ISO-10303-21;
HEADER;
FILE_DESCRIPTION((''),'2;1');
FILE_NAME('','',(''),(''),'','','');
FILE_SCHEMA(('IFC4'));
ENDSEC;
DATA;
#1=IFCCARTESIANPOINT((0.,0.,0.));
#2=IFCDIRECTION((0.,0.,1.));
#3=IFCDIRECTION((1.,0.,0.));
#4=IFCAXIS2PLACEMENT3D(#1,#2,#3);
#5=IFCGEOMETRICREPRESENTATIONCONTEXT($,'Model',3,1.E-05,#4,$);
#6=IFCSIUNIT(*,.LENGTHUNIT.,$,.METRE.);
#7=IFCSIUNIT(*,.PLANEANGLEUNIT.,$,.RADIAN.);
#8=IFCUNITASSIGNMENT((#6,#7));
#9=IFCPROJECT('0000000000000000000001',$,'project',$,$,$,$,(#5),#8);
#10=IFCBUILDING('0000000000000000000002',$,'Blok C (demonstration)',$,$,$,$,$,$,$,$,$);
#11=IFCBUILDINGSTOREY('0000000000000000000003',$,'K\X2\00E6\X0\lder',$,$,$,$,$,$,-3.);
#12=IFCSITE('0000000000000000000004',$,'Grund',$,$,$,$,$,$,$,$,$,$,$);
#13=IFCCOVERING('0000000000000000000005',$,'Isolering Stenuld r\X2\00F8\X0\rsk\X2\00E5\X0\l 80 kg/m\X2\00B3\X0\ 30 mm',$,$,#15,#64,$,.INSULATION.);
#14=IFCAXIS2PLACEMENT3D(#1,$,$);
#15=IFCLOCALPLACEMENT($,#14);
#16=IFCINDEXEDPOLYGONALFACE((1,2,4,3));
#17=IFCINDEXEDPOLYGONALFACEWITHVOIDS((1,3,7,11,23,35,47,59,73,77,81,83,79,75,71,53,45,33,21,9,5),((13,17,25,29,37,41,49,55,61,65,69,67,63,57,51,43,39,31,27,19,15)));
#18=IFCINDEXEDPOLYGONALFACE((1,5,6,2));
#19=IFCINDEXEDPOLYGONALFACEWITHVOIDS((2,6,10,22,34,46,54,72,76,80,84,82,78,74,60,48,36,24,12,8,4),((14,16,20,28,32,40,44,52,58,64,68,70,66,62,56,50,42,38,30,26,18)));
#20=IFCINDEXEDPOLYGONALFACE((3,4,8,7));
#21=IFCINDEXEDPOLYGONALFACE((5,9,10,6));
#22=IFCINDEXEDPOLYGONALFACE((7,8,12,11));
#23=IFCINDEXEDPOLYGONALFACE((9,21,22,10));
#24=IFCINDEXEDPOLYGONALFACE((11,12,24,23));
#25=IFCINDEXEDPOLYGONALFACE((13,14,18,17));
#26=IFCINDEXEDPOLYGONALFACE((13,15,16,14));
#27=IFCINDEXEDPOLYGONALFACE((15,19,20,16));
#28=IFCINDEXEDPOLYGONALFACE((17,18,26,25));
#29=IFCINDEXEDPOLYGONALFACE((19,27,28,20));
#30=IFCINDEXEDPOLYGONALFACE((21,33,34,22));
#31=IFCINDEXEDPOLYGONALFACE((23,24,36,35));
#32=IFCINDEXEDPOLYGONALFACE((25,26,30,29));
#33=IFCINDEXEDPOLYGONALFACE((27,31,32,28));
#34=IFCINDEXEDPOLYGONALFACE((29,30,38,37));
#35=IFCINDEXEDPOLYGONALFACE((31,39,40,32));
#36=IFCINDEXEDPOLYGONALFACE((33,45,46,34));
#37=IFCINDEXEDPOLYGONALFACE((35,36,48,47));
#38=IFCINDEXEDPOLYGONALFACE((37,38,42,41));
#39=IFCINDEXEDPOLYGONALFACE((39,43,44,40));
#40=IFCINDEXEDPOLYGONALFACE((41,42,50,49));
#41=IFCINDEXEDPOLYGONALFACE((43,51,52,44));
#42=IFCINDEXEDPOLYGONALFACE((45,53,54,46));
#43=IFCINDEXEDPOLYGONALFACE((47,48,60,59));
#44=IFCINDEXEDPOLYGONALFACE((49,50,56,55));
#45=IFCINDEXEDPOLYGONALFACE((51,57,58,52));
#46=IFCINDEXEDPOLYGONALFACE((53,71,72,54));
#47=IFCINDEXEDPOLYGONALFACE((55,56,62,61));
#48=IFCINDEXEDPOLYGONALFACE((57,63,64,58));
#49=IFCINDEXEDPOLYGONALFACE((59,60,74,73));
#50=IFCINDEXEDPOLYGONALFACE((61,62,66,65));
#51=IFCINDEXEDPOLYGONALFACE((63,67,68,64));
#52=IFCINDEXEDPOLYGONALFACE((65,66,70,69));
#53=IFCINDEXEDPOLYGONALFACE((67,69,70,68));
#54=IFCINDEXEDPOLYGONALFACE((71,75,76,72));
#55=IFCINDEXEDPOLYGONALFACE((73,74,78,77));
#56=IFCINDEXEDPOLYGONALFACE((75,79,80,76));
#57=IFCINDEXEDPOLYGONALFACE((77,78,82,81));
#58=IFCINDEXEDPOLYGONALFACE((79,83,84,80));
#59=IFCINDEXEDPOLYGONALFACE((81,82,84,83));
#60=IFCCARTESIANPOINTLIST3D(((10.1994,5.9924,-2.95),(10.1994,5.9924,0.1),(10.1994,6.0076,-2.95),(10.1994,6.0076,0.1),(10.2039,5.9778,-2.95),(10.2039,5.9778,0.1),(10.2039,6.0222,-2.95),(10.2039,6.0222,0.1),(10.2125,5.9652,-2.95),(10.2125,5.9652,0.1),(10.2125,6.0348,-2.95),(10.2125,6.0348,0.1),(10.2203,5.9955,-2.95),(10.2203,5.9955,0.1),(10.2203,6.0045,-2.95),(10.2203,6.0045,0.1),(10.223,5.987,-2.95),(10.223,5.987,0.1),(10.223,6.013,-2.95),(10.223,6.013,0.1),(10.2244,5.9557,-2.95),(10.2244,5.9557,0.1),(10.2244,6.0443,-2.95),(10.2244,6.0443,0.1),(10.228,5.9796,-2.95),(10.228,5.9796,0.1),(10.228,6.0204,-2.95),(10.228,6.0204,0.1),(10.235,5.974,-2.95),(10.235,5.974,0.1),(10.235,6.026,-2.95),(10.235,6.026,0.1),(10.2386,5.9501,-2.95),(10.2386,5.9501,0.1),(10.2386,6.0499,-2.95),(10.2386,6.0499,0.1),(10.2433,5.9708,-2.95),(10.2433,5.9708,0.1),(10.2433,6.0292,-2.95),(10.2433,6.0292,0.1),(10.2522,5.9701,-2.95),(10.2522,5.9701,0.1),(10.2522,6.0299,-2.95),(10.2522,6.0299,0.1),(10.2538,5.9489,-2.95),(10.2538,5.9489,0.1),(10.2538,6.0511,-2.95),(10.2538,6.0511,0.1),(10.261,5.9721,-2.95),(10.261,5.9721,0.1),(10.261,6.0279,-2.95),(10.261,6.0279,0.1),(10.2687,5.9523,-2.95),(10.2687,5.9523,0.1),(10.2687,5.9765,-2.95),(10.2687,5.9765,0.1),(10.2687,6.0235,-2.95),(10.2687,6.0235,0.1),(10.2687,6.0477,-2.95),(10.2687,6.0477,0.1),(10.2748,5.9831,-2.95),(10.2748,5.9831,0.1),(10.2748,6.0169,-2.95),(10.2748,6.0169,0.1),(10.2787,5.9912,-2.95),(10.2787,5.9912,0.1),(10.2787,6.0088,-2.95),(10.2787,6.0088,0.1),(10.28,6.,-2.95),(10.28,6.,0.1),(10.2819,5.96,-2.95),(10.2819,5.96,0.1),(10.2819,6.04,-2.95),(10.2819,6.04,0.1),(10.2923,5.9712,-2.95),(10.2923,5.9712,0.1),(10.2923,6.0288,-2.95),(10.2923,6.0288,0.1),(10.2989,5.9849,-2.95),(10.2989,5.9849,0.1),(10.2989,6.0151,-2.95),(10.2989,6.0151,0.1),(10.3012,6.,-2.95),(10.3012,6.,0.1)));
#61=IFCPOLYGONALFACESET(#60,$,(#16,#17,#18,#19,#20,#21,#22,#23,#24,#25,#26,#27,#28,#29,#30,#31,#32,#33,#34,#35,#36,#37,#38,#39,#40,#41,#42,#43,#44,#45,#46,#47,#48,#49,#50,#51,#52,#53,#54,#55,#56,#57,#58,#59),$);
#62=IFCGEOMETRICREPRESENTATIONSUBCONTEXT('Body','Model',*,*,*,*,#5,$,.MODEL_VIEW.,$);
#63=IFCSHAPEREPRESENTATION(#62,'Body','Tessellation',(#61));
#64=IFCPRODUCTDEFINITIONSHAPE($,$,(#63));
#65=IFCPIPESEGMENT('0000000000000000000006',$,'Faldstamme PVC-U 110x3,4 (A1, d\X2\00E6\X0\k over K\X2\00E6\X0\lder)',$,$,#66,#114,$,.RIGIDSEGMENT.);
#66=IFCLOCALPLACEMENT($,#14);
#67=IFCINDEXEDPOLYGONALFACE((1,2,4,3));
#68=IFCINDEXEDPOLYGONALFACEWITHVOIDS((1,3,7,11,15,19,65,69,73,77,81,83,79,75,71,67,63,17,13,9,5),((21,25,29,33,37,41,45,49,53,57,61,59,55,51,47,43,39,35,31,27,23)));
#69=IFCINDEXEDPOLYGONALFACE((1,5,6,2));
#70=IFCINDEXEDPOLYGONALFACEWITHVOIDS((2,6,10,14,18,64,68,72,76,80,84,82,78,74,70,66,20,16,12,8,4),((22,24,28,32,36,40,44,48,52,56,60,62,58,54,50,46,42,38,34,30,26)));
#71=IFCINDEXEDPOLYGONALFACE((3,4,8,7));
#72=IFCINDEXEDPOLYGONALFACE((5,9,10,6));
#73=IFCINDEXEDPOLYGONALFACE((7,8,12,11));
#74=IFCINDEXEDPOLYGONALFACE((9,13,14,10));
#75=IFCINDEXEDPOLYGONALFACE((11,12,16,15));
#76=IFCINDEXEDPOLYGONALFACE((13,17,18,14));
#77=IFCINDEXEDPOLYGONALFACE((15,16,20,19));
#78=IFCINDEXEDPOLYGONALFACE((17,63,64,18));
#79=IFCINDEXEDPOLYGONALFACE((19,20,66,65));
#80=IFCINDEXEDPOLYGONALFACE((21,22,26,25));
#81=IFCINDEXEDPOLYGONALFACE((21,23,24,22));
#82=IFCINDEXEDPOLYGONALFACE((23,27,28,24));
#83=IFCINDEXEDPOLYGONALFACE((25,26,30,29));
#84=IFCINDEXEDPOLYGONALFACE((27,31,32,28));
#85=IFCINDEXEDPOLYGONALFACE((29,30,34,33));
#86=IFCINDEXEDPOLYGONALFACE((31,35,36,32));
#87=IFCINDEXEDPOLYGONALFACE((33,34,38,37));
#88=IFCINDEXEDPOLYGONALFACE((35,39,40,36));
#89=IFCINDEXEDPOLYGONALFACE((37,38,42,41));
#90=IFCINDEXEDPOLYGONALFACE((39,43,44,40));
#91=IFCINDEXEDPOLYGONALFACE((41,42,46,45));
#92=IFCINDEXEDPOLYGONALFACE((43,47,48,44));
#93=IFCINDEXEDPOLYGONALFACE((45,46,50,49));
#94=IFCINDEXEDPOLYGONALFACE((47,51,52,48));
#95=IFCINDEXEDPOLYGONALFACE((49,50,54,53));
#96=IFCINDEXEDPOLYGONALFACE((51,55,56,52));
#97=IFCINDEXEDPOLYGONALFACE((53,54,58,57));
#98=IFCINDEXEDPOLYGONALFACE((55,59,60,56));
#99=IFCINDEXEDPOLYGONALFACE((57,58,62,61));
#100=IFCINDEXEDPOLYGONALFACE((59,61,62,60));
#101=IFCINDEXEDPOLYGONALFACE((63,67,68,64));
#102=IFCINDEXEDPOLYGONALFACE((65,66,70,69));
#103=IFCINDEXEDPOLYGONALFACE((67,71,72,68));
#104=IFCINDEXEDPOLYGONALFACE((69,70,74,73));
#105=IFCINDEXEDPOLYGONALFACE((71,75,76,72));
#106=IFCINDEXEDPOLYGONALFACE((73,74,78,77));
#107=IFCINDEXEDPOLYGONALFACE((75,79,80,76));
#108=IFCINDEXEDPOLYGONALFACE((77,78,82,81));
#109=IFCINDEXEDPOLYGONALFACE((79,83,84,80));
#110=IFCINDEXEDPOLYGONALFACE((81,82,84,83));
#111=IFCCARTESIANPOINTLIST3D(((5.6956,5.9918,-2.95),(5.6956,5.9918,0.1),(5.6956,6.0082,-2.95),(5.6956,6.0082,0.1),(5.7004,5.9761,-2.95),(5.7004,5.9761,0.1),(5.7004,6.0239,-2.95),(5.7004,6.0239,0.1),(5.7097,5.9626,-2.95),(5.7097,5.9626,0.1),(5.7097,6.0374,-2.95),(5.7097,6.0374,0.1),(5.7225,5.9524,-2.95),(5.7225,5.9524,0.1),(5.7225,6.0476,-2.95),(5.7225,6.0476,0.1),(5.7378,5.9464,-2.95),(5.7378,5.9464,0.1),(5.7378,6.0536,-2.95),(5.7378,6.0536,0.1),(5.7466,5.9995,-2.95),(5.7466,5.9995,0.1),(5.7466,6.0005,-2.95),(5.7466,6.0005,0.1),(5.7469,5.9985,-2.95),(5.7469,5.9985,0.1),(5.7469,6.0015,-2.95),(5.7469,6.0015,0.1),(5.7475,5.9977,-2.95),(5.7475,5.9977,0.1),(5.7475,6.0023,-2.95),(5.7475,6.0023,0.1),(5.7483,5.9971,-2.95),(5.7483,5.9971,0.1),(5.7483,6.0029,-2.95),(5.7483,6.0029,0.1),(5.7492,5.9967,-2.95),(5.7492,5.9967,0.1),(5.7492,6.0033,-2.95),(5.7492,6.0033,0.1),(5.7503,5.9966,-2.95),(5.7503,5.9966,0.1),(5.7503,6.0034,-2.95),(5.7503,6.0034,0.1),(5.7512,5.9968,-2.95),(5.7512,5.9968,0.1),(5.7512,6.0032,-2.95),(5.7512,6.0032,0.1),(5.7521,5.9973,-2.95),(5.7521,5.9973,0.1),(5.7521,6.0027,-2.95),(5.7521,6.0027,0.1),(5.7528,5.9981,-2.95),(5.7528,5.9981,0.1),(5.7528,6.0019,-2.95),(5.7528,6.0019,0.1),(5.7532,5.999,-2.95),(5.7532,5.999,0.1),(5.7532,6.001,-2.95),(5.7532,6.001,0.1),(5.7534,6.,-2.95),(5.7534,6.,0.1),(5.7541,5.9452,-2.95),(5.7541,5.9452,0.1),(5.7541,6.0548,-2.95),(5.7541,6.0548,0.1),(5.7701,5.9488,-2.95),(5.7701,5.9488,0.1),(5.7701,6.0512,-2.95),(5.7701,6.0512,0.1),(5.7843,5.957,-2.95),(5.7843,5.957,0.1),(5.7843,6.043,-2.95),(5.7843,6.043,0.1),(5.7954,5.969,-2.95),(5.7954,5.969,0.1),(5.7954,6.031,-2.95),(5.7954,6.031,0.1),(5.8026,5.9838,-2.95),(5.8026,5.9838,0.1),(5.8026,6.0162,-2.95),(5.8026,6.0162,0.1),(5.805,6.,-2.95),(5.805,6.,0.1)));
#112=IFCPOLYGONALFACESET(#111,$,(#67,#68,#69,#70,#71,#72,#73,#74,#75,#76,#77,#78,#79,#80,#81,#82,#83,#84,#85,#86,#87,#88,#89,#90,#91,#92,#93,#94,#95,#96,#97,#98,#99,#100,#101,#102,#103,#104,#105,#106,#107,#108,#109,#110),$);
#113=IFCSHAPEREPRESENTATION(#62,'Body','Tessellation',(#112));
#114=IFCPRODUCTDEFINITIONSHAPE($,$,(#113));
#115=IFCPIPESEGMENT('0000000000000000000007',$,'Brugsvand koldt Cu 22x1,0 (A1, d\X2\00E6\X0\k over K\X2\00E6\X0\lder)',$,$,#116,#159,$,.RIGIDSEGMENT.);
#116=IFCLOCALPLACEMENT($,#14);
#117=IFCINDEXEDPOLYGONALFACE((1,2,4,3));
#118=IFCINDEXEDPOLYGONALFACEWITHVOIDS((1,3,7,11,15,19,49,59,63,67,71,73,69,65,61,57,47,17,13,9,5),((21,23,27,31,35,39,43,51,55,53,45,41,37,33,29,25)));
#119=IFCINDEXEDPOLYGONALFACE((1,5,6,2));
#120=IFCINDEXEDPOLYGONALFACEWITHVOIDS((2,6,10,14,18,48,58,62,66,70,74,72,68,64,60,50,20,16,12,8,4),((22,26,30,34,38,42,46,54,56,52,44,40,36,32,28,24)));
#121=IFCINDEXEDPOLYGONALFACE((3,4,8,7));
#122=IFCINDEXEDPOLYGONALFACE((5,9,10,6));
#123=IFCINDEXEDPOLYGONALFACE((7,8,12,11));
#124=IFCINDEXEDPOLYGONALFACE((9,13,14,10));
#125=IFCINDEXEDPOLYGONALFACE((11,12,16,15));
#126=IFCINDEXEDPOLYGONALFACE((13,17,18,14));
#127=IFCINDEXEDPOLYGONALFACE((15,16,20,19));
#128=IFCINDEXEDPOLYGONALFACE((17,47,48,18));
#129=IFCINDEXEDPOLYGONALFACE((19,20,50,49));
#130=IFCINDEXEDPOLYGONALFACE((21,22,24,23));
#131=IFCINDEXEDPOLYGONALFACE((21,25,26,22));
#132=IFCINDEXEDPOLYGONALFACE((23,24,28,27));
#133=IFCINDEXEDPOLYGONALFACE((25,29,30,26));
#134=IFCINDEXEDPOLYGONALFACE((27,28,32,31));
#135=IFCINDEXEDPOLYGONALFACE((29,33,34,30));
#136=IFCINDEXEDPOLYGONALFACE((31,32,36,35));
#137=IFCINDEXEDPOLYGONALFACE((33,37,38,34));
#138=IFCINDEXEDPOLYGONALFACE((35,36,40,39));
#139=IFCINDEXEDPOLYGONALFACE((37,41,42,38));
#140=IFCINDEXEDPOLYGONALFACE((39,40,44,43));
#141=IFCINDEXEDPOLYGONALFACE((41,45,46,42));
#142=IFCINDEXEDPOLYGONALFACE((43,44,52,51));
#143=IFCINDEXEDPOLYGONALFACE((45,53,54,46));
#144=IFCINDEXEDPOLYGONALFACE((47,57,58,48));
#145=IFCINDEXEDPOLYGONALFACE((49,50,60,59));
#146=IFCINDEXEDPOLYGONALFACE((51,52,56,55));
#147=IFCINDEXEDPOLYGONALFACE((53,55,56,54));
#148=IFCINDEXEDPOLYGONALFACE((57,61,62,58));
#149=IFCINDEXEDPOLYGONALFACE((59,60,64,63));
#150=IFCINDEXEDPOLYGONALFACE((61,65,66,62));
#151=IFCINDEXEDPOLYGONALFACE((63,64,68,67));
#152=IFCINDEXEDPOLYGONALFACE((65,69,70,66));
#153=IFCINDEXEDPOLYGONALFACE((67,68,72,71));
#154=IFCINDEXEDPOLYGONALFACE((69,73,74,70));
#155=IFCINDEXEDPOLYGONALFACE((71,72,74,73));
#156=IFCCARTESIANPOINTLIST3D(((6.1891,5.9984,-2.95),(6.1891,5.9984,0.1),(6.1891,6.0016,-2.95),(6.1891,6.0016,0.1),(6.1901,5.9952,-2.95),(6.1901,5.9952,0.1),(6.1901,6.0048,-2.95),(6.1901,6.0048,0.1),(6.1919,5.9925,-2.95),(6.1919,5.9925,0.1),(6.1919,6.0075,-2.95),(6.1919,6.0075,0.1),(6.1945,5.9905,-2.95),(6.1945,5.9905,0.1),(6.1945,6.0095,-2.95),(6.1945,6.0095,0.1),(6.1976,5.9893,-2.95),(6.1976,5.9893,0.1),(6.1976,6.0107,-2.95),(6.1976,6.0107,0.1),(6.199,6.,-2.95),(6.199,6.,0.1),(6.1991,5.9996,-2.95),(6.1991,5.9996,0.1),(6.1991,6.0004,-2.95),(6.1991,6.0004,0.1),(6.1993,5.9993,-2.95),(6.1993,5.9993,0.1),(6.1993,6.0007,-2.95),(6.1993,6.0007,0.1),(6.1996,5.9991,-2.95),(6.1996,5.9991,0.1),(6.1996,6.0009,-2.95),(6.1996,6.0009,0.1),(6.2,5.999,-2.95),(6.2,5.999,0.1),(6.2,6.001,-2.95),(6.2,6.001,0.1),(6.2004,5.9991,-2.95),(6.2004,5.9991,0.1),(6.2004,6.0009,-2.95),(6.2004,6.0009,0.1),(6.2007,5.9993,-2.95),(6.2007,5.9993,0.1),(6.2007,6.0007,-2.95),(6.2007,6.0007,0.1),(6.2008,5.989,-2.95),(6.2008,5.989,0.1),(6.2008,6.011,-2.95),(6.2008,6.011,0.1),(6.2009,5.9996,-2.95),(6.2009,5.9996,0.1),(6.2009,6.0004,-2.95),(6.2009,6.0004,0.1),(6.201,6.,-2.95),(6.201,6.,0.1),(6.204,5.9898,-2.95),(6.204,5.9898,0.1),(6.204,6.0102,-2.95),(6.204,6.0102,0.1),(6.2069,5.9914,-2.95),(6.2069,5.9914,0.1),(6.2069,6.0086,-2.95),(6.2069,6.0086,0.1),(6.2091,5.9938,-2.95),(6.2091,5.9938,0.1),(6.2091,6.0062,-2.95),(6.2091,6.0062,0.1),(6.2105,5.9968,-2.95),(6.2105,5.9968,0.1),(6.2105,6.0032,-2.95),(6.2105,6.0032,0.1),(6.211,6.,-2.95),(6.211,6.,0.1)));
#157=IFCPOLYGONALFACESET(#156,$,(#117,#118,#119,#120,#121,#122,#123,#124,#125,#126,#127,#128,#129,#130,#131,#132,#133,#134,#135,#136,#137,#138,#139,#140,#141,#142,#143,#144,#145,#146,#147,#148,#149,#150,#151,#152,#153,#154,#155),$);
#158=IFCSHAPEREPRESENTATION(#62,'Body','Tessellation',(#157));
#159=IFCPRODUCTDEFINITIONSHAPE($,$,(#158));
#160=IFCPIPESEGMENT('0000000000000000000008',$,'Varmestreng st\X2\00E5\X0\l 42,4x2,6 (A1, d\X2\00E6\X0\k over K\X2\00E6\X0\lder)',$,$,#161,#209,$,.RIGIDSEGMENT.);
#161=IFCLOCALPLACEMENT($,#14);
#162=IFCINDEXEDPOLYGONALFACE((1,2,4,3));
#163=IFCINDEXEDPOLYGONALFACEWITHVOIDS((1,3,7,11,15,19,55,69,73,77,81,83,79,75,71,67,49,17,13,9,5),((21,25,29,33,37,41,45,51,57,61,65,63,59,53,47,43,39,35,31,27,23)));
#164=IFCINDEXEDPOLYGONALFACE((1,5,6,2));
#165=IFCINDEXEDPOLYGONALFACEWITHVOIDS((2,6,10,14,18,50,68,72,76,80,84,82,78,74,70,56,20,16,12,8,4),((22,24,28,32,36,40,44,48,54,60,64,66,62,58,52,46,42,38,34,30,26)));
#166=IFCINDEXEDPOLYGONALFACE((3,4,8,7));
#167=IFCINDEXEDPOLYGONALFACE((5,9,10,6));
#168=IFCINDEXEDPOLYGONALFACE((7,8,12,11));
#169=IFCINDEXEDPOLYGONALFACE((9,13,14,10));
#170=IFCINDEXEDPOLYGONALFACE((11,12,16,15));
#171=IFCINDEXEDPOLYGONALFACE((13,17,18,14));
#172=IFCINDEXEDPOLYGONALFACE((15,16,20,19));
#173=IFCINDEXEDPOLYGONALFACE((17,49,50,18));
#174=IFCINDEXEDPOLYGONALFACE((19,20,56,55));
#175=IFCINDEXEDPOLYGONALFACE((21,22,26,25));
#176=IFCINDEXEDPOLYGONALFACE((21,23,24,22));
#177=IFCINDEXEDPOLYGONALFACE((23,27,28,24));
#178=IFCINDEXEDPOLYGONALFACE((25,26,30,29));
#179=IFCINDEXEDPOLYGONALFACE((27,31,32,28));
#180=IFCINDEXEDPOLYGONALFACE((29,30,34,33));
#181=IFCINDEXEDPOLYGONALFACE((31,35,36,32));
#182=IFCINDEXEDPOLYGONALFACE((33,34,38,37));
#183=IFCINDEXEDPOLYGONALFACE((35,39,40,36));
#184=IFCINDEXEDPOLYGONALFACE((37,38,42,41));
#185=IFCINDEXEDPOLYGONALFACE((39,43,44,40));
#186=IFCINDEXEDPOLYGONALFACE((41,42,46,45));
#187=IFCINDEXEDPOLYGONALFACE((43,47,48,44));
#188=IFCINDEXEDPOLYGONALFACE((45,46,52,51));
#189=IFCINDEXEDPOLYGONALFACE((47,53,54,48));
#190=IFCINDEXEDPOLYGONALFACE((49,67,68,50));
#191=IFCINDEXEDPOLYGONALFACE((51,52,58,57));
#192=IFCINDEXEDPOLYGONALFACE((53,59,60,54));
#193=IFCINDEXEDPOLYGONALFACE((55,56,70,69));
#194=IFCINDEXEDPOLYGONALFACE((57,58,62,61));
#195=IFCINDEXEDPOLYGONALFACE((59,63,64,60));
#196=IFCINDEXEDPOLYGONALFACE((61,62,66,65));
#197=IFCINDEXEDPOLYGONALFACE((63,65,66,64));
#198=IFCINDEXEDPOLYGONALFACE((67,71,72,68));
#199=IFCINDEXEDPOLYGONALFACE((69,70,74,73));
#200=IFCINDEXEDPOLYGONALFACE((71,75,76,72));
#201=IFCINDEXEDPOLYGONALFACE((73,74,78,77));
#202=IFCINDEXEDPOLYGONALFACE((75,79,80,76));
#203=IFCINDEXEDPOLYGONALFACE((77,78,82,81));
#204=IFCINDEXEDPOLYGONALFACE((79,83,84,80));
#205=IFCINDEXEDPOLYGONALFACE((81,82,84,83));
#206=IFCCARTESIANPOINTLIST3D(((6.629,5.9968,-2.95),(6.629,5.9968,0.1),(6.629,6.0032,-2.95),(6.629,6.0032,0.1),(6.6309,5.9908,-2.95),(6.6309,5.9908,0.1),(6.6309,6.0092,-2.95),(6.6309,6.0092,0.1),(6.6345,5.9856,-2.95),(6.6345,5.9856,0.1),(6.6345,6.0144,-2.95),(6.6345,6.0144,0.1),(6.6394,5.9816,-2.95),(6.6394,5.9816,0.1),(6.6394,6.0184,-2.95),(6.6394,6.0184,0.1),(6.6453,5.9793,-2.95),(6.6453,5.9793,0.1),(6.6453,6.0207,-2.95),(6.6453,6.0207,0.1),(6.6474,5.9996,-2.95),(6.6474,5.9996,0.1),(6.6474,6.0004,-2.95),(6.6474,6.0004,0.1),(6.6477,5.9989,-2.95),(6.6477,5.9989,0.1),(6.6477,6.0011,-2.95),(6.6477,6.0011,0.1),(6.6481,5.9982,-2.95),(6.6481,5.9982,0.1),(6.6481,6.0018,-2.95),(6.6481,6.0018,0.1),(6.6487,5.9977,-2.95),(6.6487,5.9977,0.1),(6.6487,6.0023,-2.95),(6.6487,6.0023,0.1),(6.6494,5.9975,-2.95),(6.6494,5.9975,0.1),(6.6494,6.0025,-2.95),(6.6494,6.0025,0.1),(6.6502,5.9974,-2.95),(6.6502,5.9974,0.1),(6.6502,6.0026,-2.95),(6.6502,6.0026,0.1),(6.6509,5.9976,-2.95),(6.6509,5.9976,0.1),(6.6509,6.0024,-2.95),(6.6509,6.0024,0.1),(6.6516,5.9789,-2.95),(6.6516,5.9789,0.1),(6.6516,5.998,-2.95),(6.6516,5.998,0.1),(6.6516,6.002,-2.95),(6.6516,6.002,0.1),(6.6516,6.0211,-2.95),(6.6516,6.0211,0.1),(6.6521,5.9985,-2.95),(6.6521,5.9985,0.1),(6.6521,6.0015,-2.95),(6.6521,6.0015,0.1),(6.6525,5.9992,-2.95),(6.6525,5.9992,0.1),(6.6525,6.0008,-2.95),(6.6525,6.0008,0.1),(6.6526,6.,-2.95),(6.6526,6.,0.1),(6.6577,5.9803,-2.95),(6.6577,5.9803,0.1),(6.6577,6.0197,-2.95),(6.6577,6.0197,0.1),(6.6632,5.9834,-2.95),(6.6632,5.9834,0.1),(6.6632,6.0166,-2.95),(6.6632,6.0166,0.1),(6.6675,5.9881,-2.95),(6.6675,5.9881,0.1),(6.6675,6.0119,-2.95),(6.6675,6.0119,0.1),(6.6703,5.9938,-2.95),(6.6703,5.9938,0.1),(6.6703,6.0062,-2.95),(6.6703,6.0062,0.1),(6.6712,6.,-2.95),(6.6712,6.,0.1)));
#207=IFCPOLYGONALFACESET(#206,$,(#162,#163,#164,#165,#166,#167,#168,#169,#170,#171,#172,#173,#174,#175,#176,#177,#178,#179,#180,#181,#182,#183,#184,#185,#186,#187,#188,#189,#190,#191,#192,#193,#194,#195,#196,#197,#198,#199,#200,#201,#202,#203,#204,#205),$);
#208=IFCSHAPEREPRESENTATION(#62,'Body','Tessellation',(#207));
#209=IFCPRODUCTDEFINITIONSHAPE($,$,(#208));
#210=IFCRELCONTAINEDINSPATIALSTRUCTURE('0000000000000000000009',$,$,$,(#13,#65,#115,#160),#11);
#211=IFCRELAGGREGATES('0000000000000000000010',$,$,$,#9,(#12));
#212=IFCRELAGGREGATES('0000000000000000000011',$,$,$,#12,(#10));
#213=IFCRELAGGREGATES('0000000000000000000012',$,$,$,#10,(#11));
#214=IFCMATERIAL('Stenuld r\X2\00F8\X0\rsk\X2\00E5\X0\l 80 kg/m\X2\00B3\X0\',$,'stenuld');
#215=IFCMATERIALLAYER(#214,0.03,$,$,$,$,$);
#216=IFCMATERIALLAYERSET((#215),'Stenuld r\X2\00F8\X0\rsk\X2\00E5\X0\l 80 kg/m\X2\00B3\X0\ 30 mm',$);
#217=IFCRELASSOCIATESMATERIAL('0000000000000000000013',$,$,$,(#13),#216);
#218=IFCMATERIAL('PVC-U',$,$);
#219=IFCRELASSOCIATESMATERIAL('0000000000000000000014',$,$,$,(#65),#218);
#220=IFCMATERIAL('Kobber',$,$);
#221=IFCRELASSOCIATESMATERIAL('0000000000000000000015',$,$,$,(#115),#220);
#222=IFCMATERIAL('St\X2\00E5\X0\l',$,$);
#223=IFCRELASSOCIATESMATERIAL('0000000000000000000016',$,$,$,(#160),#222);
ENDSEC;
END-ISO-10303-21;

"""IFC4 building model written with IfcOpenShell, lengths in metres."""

from ifc_helpers import new_model, si_unit, frame, origin_with_axes, place, context, subcontext, project, spatial, hollow_circle, extrude, material, layer, layer_set, element, save


model = new_model("IFC4")

# Units and contexts
model_context = context("Model", 3, precision=1e-05, world=origin_with_axes())
body_context = subcontext(model_context, "Body", "Model", "MODEL_VIEW")
ifc_project = project(units=[si_unit("LENGTHUNIT", "METRE"), si_unit("PLANEANGLEUNIT", "RADIAN")], contexts=[model_context])

# Site, building, storey
site = spatial("IfcSite", under=ifc_project, Name="Grund")
building = spatial("IfcBuilding", under=site, Name="Blok C (demonstration)")
storey = spatial("IfcBuildingStorey", under=building, Name="Kælder", Elevation=-3.0)

# Covering
ifc_material_1 = material(Name="Stenuld rørskål 80 kg/m³", Category="stenuld")
ifc_layer_1 = layer(ifc_material_1, 0.03)
ifc_layer_set_1 = layer_set([ifc_layer_1], Name="Stenuld rørskål 80 kg/m³ 30 mm")
covering_1_placement = place(None, origin_with_axes())
element("IfcCovering", 1, at=covering_1_placement, inside=storey, material=ifc_layer_set_1, Name="Isolering Stenuld rørskål 80 kg/m³ 30 mm", PredefinedType="INSULATION", context=body_context, shape_type="SweptSolid", body=[
    extrude(hollow_circle(Radius=0.0512, WallThickness=0.0212), frame((10.25, 6.0, -2.95), z_axis=(0.0, 0.0, 1.0), x_axis=(1.0, 0.0, 0.0)), (0.0, 0.0, 1.0), 3.05),
])

# Pipe segments
ifc_material_2 = material(Name="PVC-U")
pipe_segment_1_placement = place(None, origin_with_axes())
element("IfcPipeSegment", 2, at=pipe_segment_1_placement, inside=storey, material=ifc_material_2, Name="Faldstamme PVC-U 110x3,4 (A1, dæk over Kælder)", PredefinedType="RIGIDSEGMENT", context=body_context, shape_type="SweptSolid", body=[
    extrude(hollow_circle(Radius=0.055, WallThickness=0.0516), frame((5.75, 6.0, -2.95), z_axis=(0.0, 0.0, 1.0), x_axis=(1.0, 0.0, 0.0)), (0.0, 0.0, 1.0), 3.05),
])
ifc_material_3 = material(Name="Kobber")
pipe_segment_2_placement = place(None, origin_with_axes())
element("IfcPipeSegment", 3, at=pipe_segment_2_placement, inside=storey, material=ifc_material_3, Name="Brugsvand koldt Cu 22x1,0 (A1, dæk over Kælder)", PredefinedType="RIGIDSEGMENT", context=body_context, shape_type="SweptSolid", body=[
    extrude(hollow_circle(Radius=0.011, WallThickness=0.01), frame((6.2, 6.0, -2.95), z_axis=(0.0, 0.0, 1.0), x_axis=(1.0, 0.0, 0.0)), (0.0, 0.0, 1.0), 3.05),
])
ifc_material_4 = material(Name="Stål")
pipe_segment_3_placement = place(None, origin_with_axes())
element("IfcPipeSegment", 4, at=pipe_segment_3_placement, inside=storey, material=ifc_material_4, Name="Varmestreng stål 42,4x2,6 (A1, dæk over Kælder)", PredefinedType="RIGIDSEGMENT", context=body_context, shape_type="SweptSolid", body=[
    extrude(hollow_circle(Radius=0.0212, WallThickness=0.0186), frame((6.65, 6.0, -2.95), z_axis=(0.0, 0.0, 1.0), x_axis=(1.0, 0.0, 0.0)), (0.0, 0.0, 1.0), 3.05),
])

save(model, "model.ifc")
